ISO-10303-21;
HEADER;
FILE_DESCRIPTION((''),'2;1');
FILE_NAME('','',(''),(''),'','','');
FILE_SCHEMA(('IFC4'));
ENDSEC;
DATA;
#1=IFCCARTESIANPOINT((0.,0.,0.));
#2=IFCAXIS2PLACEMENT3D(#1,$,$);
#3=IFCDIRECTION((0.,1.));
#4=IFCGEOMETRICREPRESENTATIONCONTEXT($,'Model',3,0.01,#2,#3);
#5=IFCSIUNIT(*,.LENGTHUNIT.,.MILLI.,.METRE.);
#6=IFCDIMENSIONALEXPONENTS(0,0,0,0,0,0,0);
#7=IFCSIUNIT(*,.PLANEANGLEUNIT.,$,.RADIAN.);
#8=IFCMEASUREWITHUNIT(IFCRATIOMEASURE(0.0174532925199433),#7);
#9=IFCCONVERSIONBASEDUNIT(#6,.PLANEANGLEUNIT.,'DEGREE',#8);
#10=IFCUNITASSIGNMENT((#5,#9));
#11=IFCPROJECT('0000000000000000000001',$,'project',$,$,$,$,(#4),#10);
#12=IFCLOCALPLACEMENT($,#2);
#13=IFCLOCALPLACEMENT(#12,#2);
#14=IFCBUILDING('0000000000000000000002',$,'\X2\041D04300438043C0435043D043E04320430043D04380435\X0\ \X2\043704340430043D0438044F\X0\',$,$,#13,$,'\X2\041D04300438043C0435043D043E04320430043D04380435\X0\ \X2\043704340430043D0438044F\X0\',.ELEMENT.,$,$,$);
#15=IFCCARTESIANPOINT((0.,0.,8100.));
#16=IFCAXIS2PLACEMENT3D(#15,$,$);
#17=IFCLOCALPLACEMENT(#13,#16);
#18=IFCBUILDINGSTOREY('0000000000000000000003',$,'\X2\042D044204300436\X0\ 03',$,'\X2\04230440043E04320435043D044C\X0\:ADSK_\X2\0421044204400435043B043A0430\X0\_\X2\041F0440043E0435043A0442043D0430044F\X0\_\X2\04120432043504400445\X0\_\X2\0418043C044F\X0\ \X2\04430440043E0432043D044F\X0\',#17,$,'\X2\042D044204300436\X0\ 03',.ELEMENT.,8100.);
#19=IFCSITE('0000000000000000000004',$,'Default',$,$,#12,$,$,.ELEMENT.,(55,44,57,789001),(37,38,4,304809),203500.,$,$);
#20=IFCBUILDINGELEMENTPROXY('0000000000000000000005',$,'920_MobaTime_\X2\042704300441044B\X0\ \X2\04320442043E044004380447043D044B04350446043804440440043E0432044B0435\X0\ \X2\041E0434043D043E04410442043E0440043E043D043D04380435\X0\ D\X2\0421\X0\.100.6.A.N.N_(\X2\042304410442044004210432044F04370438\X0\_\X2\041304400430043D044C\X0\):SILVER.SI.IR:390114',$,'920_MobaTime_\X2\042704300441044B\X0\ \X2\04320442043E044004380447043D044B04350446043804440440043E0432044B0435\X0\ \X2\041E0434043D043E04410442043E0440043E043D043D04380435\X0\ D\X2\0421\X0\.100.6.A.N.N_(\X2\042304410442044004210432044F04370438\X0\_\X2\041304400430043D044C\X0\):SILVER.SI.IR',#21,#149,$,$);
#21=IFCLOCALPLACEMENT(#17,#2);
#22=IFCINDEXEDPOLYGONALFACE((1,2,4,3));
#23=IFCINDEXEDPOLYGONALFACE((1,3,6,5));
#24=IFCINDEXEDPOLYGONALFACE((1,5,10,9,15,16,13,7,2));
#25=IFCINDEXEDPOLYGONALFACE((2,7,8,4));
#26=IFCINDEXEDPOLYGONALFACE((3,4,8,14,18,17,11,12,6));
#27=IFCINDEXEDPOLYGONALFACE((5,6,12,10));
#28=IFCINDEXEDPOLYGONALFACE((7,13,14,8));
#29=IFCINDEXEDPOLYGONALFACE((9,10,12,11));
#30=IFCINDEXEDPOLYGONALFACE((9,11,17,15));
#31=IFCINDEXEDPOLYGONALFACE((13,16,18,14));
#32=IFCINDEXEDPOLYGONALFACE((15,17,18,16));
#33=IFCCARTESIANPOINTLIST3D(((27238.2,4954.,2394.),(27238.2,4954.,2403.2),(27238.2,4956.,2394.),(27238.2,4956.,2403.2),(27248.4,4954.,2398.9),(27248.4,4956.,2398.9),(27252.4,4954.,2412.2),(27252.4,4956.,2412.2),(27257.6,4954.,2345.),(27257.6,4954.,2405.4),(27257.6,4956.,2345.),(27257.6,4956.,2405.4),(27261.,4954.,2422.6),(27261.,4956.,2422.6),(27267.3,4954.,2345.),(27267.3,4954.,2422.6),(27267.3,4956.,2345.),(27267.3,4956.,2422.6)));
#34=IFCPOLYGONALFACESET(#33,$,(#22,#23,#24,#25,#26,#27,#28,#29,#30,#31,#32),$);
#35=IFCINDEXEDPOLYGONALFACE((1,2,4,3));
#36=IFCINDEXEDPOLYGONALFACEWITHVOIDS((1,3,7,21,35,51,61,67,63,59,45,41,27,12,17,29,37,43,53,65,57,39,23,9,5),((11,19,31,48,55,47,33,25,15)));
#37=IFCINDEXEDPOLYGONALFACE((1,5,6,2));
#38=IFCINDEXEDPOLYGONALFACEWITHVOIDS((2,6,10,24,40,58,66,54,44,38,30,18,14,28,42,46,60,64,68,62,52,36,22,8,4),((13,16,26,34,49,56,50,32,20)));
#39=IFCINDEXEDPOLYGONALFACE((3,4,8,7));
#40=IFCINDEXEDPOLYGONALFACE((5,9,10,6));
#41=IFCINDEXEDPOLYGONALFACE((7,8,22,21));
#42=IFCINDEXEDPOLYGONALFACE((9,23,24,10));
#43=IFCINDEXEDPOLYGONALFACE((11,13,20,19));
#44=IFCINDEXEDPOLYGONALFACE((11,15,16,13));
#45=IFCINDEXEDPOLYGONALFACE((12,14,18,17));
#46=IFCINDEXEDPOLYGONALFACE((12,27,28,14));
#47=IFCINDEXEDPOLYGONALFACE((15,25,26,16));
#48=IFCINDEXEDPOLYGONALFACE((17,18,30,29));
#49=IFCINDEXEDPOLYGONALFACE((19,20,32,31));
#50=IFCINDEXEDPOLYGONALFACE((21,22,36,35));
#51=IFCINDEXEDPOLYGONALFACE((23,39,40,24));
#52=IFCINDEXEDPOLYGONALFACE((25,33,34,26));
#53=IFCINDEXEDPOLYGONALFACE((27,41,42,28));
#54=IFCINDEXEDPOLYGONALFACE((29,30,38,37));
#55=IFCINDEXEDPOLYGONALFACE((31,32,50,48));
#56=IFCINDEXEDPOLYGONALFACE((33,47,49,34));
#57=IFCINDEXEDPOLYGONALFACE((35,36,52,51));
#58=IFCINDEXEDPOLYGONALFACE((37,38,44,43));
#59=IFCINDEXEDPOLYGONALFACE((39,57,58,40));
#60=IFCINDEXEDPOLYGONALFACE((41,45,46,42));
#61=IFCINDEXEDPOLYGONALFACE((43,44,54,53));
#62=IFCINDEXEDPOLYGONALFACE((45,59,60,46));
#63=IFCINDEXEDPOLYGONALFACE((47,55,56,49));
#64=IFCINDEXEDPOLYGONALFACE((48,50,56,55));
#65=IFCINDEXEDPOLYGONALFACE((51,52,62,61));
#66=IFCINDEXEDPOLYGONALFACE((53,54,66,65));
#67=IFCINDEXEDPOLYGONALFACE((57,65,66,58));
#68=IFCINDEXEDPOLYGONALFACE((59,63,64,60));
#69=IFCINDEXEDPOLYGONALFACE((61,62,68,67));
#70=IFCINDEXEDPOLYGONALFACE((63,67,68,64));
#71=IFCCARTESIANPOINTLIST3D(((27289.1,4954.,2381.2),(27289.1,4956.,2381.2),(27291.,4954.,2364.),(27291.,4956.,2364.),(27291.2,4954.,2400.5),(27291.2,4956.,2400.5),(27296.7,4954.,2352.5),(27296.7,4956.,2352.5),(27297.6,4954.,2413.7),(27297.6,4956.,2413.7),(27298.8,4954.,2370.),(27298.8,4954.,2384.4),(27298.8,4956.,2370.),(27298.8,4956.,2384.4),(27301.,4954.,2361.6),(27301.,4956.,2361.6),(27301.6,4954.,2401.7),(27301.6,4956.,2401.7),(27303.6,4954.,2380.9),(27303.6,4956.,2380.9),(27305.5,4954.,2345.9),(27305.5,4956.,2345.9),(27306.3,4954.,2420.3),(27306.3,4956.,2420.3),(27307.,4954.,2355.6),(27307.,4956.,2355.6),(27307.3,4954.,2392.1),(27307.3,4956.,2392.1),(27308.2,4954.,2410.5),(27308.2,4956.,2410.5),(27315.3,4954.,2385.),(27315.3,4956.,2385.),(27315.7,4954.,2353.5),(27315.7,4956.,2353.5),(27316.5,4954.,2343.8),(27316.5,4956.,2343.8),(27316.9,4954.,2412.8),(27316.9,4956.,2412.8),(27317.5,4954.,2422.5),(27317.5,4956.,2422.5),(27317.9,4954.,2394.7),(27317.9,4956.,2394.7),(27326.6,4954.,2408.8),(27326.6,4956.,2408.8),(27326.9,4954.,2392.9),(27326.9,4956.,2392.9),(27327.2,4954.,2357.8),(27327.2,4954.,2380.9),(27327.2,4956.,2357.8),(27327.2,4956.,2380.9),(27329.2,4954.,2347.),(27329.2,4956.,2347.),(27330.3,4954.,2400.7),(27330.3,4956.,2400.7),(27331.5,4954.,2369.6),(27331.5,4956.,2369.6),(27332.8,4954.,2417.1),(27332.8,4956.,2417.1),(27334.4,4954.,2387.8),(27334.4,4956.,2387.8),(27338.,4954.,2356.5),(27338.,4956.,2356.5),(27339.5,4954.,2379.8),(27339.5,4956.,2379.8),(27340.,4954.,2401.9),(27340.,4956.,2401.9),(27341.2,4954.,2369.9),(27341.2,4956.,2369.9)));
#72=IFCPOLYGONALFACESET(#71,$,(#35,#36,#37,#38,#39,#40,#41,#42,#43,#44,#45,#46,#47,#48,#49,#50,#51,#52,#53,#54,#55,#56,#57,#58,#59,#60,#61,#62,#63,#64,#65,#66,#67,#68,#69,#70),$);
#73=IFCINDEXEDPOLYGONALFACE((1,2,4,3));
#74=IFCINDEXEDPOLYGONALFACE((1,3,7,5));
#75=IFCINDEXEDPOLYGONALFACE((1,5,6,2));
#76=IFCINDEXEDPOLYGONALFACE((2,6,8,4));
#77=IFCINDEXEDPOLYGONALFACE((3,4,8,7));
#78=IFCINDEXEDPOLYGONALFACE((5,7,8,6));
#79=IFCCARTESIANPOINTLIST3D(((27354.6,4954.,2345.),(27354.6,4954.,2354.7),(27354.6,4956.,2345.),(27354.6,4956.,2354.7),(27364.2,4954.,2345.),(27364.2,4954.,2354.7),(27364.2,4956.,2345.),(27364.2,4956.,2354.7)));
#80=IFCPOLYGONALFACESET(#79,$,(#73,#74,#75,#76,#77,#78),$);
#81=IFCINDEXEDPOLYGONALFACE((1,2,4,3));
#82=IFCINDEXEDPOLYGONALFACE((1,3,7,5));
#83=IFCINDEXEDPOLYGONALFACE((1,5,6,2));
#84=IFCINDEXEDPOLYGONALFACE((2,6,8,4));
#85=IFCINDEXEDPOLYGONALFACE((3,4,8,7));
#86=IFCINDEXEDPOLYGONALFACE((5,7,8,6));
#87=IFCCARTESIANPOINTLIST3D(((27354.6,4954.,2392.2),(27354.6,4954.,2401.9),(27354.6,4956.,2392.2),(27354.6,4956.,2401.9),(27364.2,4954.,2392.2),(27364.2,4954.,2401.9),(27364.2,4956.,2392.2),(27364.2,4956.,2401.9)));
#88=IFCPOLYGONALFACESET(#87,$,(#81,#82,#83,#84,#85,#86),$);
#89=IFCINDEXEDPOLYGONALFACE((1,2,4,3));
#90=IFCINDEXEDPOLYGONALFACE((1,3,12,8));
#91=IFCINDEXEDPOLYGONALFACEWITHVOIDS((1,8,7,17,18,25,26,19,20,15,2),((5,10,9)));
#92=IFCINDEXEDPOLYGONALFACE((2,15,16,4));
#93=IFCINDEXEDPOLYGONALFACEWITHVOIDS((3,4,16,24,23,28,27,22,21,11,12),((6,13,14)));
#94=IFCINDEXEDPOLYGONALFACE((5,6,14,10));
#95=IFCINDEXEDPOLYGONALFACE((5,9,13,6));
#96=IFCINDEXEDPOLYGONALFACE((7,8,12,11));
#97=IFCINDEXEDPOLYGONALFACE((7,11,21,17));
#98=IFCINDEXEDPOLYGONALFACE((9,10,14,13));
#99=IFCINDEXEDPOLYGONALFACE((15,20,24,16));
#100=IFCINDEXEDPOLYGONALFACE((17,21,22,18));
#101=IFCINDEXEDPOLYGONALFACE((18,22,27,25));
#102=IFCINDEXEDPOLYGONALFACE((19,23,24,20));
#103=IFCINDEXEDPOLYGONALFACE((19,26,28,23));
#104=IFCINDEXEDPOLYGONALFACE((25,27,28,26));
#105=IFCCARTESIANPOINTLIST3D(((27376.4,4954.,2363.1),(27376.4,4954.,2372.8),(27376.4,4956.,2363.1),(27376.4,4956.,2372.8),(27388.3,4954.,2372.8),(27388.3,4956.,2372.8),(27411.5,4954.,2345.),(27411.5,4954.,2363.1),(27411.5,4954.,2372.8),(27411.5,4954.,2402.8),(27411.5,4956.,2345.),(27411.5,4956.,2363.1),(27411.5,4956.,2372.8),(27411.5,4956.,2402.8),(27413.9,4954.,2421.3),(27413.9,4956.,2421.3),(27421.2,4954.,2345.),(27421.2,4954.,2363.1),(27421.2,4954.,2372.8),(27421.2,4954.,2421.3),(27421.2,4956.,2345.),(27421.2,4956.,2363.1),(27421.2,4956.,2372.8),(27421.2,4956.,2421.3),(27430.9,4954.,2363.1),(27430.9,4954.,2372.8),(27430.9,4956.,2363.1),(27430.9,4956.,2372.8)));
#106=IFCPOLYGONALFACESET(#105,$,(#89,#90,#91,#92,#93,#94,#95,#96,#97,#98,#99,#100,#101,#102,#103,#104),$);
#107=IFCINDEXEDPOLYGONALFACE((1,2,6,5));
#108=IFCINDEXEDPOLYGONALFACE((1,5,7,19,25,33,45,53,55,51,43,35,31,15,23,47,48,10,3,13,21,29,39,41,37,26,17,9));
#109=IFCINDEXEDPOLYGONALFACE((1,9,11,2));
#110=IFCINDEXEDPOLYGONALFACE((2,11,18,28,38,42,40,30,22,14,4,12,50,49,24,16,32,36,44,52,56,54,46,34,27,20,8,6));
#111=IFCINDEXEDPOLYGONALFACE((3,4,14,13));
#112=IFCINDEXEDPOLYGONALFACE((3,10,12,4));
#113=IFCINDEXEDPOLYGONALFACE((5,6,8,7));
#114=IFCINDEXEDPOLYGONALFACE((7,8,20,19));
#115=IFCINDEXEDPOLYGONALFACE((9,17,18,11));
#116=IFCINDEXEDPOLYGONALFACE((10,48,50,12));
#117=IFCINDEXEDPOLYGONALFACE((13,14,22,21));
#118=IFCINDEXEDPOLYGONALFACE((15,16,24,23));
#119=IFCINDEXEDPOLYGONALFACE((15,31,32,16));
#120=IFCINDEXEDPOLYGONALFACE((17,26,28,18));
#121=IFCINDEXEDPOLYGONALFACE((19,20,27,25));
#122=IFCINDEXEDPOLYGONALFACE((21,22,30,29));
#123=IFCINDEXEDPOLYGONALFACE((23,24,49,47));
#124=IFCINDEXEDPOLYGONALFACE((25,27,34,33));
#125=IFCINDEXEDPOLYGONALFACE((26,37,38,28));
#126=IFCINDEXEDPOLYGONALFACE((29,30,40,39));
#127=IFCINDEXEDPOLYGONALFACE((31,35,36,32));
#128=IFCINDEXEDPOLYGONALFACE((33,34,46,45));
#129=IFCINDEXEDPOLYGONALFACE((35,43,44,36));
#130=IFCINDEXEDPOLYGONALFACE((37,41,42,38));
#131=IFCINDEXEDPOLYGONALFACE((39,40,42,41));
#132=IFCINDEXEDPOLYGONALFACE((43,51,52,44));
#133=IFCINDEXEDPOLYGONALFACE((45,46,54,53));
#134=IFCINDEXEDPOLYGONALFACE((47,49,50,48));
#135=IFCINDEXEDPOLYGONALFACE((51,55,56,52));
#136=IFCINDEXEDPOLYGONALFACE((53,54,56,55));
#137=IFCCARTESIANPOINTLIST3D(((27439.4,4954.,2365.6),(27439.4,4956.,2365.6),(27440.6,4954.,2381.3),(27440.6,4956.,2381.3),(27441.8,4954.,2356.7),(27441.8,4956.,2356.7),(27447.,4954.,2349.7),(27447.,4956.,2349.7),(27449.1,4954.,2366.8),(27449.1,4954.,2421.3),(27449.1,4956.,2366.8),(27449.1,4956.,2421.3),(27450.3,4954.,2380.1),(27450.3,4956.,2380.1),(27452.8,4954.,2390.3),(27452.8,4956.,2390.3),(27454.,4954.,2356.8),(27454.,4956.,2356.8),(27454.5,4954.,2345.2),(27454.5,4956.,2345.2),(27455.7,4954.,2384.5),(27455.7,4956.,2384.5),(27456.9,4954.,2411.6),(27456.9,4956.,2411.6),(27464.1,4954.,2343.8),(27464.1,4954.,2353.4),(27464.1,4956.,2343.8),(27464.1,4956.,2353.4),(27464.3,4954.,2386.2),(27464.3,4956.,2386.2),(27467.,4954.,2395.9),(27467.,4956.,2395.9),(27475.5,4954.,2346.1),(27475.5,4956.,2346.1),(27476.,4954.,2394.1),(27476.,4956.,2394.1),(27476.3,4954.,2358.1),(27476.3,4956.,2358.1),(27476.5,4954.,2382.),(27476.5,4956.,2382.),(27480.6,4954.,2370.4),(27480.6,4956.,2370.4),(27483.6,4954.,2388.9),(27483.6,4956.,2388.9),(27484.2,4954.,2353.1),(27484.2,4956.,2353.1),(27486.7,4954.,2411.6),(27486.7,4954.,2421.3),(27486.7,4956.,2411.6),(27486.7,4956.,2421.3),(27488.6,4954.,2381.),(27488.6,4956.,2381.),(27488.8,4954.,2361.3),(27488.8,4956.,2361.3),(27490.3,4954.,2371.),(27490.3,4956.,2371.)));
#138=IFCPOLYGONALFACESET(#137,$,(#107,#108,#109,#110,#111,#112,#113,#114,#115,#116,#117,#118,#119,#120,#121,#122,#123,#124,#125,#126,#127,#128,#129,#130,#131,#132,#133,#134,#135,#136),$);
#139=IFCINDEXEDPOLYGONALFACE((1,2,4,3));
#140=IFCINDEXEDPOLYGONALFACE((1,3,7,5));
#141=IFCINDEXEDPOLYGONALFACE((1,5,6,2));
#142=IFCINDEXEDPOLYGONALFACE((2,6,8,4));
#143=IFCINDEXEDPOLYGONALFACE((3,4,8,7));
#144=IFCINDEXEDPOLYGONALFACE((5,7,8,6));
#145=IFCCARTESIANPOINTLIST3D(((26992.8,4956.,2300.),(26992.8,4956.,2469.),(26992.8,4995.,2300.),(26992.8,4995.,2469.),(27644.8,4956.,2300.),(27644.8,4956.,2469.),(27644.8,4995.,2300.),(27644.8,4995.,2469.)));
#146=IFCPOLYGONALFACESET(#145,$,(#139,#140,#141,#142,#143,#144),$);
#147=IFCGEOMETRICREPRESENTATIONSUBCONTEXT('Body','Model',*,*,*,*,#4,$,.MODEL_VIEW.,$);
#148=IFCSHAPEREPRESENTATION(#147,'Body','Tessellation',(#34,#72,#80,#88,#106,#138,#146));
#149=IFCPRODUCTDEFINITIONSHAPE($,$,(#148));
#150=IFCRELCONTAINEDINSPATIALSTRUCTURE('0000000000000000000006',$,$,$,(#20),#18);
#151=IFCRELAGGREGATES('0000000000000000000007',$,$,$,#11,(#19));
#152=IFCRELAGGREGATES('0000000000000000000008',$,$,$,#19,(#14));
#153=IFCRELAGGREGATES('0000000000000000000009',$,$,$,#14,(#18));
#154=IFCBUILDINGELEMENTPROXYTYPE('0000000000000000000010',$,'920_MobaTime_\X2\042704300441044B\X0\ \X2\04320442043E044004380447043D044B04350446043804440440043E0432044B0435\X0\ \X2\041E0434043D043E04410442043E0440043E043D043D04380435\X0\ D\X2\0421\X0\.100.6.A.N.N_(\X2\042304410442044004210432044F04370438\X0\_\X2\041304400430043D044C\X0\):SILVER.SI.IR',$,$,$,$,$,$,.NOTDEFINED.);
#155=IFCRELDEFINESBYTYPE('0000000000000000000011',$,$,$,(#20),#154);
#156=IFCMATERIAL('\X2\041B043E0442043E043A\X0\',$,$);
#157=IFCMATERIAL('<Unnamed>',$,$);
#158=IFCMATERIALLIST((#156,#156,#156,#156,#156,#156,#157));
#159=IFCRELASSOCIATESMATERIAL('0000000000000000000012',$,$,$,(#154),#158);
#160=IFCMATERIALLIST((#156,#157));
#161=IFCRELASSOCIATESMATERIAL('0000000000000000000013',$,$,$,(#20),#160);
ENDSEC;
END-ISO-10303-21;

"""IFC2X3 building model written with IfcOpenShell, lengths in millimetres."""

from ifc_helpers import new_model, entity, si_unit, converted_unit, direction, frame, origin, origin_2d_with_axis, place, context, subcontext, project, spatial, polyline, rectangle, outline, extrude, source, transform, mapped, material, material_list, type_object, type_shapes, element, save


model = new_model("IFC2X3")

# Units and contexts
model_context = context("Model", 3, precision=0.01, world=origin(), true_north=direction((0.0, 1.0)))
body_context = subcontext(model_context, "Body", "Model", "MODEL_VIEW")
ifc_project = project(units=[si_unit("LENGTHUNIT", "METRE", prefix="MILLI"), converted_unit("PLANEANGLEUNIT", "DEGREE", entity("IfcRatioMeasure", 0.0174532925199433), si_unit("PLANEANGLEUNIT", "RADIAN"), dimensions=[0, 0, 0, 0, 0, 0, 0])], contexts=[model_context])

# Site, building, storey
site_placement = place(None, origin())
site = spatial("IfcSite", under=ifc_project, at=site_placement, Name="Default", CompositionType="ELEMENT", RefLatitude=(55, 44, 57, 789001), RefLongitude=(37, 38, 4, 304809), RefElevation=203500.0)
building_placement = place(site_placement, origin())
building = spatial("IfcBuilding", under=site, at=building_placement, Name="Наименование здания", LongName="Наименование здания", CompositionType="ELEMENT")
storey_placement = place(building_placement, frame((0.0, 0.0, 8100.0)))
storey = spatial("IfcBuildingStorey", under=building, at=storey_placement, Name="Этаж 03", ObjectType="Уровень:ADSK_Стрелка_Проектная_Вверх_Имя уровня", LongName="Этаж 03", CompositionType="ELEMENT", Elevation=8100.0)

# Building element proxy
ifc_material_1 = material(Name="Лоток")
ifc_material_2 = material(Name="<Unnamed>")
ifc_material_list_1 = material_list([ifc_material_1, ifc_material_1, ifc_material_1, ifc_material_1, ifc_material_1, ifc_material_1, ifc_material_2])
building_element_proxy_type = type_object("IfcBuildingElementProxyType", Name="920_MobaTime_Часы вторичныецифровые Односторонние DС.100.6.A.N.N_(УстрСвязи_Грань):SILVER.SI.IR", PredefinedType="NOTDEFINED", material=ifc_material_list_1)
shared_shape = source(origin(), body_context, "Body", "SweptSolid", [
    extrude(outline(polyline([(-49.3, -13.1), (28.2, -13.1), (28.2, -6.8), (17.9, 1.8), (8.8, 16.0), (-0.3, 16.0), (4.6, 5.8), (11.1, -3.4), (-49.3, -3.4), (-49.3, -13.1)])), frame((-64.6, 9.8, 39.0), z_axis=(0.0, 0.0, 1.0), x_axis=(0.0, 1.0, 0.0)), (0.0, 0.0, 1.0), 2.0),
    extrude(outline(polyline([(2.2, -27.6), (19.0, -27.6), (30.5, -16.1), (33.3, -4.9), (31.0, 5.8), (21.8, 17.2), (5.2, 27.3), (-11.1, 33.0), (-24.0, 32.7), (-33.6, 27.6), (-40.3, 18.6), (-42.8, 5.7), (-38.0, -6.3), (-27.2, -14.9), (-17.5, -17.7), (-8.2, -16.4), (-0.3, -11.9), (5.1, -4.5), (7.3, 6.2), (4.0, 17.2), (18.4, 7.3), (23.6, -2.4), (22.0, -11.4), (14.2, -18.4), (5.3, -18.3), (2.2, -27.6)]), holes=[polyline([(-9.0, 23.3), (-1.3, 14.3), (-2.5, 2.0), (-11.4, -7.0), (-23.4, -6.0), (-32.2, 2.9), (-31.2, 15.1), (-25.6, 22.1), (-17.5, 24.9), (-9.0, 23.3)])]), frame((-2.7, 3.6, 39.0), z_axis=(0.0, 0.0, 1.0), x_axis=(-0.427649, 0.903945, 0.0)), (0.0, 0.0, 1.0), 2.0),
    extrude(rectangle(XDim=9.7, YDim=9.7, at=origin_2d_with_axis()), frame((40.6, -34.7, 39.0)), (0.0, 0.0, 1.0), 2.0),
    extrude(rectangle(XDim=9.7, YDim=9.7, at=origin_2d_with_axis()), frame((40.6, 12.6, 39.0)), (0.0, 0.0, 1.0), 2.0),
    extrude(outline(polyline([(-0.9, -28.1), (8.8, -28.1), (8.8, -9.9), (18.5, -9.9), (18.5, -0.2), (8.8, -0.2), (8.8, 48.3), (1.5, 48.3), (-36.0, -0.2), (-36.0, -9.9), (-0.9, -9.9), (-0.9, -28.1)]), holes=[polyline([(-0.9, -0.2), (-24.1, -0.2), (-0.9, 29.7), (-0.9, -0.2)])]), frame((93.6, -11.4, 39.0)), (0.0, 0.0, 1.0), 2.0),
    extrude(outline(polyline([(3.3, -28.3), (12.5, -28.3), (20.5, -25.0), (26.8, -18.9), (30.7, -10.0), (31.4, 1.6), (26.9, 11.8), (20.1, 18.4), (11.1, 22.3), (1.0, 23.3), (-7.9, 20.4), (-14.9, 14.5), (-18.9, 6.2), (-17.1, -9.0), (-36.7, 0.5), (-29.1, 29.2), (-38.5, 31.7), (-48.1, -4.6), (-11.6, -23.1), (-8.0, -14.0), (-10.8, -7.6), (-10.2, 1.1), (-3.0, 11.8), (9.2, 12.8), (20.0, 5.5), (21.4, -7.5), (15.5, -16.4), (4.6, -18.6), (3.3, -28.3)])), frame((147.1, -8.5, 39.0), z_axis=(0.0, 0.0, 1.0), x_axis=(0.256974, -0.966418, 0.0)), (0.0, 0.0, 1.0), 2.0),
    extrude(rectangle(XDim=652.0, YDim=169.0, at=origin_2d_with_axis()), frame((0.0, 0.0, 0.0), z_axis=(0.0, 0.0, 1.0), x_axis=(-1.0, 0.0, 0.0)), (0.0, 0.0, 1.0), 39.0),
])
type_shapes(building_element_proxy_type, [shared_shape])
ifc_material_list_2 = material_list([ifc_material_1, ifc_material_2])
for number, where, z_axis, x_axis, name in (
    (1, (27318.8, 4995.0, 2384.5), (0.0, -1.0, 0.0), (1.0, 0.0, 0.0), "920_MobaTime_Часы вторичныецифровые Односторонние DС.100.6.A.N.N_(УстрСвязи_Грань):SILVER.SI.IR:390114"),
):
    element("IfcBuildingElementProxy", number, at=place(storey_placement, frame(where, z_axis=z_axis, x_axis=x_axis)), inside=storey, type_object=building_element_proxy_type, material=ifc_material_list_2, Name=name, ObjectType="920_MobaTime_Часы вторичныецифровые Односторонние DС.100.6.A.N.N_(УстрСвязи_Грань):SILVER.SI.IR", context=body_context, shape_type="MappedRepresentation", body=[
        mapped(shared_shape, transform((0.0, 0.0, 0.0), scale=1.0)),
    ])

save(model, "model.ifc")
